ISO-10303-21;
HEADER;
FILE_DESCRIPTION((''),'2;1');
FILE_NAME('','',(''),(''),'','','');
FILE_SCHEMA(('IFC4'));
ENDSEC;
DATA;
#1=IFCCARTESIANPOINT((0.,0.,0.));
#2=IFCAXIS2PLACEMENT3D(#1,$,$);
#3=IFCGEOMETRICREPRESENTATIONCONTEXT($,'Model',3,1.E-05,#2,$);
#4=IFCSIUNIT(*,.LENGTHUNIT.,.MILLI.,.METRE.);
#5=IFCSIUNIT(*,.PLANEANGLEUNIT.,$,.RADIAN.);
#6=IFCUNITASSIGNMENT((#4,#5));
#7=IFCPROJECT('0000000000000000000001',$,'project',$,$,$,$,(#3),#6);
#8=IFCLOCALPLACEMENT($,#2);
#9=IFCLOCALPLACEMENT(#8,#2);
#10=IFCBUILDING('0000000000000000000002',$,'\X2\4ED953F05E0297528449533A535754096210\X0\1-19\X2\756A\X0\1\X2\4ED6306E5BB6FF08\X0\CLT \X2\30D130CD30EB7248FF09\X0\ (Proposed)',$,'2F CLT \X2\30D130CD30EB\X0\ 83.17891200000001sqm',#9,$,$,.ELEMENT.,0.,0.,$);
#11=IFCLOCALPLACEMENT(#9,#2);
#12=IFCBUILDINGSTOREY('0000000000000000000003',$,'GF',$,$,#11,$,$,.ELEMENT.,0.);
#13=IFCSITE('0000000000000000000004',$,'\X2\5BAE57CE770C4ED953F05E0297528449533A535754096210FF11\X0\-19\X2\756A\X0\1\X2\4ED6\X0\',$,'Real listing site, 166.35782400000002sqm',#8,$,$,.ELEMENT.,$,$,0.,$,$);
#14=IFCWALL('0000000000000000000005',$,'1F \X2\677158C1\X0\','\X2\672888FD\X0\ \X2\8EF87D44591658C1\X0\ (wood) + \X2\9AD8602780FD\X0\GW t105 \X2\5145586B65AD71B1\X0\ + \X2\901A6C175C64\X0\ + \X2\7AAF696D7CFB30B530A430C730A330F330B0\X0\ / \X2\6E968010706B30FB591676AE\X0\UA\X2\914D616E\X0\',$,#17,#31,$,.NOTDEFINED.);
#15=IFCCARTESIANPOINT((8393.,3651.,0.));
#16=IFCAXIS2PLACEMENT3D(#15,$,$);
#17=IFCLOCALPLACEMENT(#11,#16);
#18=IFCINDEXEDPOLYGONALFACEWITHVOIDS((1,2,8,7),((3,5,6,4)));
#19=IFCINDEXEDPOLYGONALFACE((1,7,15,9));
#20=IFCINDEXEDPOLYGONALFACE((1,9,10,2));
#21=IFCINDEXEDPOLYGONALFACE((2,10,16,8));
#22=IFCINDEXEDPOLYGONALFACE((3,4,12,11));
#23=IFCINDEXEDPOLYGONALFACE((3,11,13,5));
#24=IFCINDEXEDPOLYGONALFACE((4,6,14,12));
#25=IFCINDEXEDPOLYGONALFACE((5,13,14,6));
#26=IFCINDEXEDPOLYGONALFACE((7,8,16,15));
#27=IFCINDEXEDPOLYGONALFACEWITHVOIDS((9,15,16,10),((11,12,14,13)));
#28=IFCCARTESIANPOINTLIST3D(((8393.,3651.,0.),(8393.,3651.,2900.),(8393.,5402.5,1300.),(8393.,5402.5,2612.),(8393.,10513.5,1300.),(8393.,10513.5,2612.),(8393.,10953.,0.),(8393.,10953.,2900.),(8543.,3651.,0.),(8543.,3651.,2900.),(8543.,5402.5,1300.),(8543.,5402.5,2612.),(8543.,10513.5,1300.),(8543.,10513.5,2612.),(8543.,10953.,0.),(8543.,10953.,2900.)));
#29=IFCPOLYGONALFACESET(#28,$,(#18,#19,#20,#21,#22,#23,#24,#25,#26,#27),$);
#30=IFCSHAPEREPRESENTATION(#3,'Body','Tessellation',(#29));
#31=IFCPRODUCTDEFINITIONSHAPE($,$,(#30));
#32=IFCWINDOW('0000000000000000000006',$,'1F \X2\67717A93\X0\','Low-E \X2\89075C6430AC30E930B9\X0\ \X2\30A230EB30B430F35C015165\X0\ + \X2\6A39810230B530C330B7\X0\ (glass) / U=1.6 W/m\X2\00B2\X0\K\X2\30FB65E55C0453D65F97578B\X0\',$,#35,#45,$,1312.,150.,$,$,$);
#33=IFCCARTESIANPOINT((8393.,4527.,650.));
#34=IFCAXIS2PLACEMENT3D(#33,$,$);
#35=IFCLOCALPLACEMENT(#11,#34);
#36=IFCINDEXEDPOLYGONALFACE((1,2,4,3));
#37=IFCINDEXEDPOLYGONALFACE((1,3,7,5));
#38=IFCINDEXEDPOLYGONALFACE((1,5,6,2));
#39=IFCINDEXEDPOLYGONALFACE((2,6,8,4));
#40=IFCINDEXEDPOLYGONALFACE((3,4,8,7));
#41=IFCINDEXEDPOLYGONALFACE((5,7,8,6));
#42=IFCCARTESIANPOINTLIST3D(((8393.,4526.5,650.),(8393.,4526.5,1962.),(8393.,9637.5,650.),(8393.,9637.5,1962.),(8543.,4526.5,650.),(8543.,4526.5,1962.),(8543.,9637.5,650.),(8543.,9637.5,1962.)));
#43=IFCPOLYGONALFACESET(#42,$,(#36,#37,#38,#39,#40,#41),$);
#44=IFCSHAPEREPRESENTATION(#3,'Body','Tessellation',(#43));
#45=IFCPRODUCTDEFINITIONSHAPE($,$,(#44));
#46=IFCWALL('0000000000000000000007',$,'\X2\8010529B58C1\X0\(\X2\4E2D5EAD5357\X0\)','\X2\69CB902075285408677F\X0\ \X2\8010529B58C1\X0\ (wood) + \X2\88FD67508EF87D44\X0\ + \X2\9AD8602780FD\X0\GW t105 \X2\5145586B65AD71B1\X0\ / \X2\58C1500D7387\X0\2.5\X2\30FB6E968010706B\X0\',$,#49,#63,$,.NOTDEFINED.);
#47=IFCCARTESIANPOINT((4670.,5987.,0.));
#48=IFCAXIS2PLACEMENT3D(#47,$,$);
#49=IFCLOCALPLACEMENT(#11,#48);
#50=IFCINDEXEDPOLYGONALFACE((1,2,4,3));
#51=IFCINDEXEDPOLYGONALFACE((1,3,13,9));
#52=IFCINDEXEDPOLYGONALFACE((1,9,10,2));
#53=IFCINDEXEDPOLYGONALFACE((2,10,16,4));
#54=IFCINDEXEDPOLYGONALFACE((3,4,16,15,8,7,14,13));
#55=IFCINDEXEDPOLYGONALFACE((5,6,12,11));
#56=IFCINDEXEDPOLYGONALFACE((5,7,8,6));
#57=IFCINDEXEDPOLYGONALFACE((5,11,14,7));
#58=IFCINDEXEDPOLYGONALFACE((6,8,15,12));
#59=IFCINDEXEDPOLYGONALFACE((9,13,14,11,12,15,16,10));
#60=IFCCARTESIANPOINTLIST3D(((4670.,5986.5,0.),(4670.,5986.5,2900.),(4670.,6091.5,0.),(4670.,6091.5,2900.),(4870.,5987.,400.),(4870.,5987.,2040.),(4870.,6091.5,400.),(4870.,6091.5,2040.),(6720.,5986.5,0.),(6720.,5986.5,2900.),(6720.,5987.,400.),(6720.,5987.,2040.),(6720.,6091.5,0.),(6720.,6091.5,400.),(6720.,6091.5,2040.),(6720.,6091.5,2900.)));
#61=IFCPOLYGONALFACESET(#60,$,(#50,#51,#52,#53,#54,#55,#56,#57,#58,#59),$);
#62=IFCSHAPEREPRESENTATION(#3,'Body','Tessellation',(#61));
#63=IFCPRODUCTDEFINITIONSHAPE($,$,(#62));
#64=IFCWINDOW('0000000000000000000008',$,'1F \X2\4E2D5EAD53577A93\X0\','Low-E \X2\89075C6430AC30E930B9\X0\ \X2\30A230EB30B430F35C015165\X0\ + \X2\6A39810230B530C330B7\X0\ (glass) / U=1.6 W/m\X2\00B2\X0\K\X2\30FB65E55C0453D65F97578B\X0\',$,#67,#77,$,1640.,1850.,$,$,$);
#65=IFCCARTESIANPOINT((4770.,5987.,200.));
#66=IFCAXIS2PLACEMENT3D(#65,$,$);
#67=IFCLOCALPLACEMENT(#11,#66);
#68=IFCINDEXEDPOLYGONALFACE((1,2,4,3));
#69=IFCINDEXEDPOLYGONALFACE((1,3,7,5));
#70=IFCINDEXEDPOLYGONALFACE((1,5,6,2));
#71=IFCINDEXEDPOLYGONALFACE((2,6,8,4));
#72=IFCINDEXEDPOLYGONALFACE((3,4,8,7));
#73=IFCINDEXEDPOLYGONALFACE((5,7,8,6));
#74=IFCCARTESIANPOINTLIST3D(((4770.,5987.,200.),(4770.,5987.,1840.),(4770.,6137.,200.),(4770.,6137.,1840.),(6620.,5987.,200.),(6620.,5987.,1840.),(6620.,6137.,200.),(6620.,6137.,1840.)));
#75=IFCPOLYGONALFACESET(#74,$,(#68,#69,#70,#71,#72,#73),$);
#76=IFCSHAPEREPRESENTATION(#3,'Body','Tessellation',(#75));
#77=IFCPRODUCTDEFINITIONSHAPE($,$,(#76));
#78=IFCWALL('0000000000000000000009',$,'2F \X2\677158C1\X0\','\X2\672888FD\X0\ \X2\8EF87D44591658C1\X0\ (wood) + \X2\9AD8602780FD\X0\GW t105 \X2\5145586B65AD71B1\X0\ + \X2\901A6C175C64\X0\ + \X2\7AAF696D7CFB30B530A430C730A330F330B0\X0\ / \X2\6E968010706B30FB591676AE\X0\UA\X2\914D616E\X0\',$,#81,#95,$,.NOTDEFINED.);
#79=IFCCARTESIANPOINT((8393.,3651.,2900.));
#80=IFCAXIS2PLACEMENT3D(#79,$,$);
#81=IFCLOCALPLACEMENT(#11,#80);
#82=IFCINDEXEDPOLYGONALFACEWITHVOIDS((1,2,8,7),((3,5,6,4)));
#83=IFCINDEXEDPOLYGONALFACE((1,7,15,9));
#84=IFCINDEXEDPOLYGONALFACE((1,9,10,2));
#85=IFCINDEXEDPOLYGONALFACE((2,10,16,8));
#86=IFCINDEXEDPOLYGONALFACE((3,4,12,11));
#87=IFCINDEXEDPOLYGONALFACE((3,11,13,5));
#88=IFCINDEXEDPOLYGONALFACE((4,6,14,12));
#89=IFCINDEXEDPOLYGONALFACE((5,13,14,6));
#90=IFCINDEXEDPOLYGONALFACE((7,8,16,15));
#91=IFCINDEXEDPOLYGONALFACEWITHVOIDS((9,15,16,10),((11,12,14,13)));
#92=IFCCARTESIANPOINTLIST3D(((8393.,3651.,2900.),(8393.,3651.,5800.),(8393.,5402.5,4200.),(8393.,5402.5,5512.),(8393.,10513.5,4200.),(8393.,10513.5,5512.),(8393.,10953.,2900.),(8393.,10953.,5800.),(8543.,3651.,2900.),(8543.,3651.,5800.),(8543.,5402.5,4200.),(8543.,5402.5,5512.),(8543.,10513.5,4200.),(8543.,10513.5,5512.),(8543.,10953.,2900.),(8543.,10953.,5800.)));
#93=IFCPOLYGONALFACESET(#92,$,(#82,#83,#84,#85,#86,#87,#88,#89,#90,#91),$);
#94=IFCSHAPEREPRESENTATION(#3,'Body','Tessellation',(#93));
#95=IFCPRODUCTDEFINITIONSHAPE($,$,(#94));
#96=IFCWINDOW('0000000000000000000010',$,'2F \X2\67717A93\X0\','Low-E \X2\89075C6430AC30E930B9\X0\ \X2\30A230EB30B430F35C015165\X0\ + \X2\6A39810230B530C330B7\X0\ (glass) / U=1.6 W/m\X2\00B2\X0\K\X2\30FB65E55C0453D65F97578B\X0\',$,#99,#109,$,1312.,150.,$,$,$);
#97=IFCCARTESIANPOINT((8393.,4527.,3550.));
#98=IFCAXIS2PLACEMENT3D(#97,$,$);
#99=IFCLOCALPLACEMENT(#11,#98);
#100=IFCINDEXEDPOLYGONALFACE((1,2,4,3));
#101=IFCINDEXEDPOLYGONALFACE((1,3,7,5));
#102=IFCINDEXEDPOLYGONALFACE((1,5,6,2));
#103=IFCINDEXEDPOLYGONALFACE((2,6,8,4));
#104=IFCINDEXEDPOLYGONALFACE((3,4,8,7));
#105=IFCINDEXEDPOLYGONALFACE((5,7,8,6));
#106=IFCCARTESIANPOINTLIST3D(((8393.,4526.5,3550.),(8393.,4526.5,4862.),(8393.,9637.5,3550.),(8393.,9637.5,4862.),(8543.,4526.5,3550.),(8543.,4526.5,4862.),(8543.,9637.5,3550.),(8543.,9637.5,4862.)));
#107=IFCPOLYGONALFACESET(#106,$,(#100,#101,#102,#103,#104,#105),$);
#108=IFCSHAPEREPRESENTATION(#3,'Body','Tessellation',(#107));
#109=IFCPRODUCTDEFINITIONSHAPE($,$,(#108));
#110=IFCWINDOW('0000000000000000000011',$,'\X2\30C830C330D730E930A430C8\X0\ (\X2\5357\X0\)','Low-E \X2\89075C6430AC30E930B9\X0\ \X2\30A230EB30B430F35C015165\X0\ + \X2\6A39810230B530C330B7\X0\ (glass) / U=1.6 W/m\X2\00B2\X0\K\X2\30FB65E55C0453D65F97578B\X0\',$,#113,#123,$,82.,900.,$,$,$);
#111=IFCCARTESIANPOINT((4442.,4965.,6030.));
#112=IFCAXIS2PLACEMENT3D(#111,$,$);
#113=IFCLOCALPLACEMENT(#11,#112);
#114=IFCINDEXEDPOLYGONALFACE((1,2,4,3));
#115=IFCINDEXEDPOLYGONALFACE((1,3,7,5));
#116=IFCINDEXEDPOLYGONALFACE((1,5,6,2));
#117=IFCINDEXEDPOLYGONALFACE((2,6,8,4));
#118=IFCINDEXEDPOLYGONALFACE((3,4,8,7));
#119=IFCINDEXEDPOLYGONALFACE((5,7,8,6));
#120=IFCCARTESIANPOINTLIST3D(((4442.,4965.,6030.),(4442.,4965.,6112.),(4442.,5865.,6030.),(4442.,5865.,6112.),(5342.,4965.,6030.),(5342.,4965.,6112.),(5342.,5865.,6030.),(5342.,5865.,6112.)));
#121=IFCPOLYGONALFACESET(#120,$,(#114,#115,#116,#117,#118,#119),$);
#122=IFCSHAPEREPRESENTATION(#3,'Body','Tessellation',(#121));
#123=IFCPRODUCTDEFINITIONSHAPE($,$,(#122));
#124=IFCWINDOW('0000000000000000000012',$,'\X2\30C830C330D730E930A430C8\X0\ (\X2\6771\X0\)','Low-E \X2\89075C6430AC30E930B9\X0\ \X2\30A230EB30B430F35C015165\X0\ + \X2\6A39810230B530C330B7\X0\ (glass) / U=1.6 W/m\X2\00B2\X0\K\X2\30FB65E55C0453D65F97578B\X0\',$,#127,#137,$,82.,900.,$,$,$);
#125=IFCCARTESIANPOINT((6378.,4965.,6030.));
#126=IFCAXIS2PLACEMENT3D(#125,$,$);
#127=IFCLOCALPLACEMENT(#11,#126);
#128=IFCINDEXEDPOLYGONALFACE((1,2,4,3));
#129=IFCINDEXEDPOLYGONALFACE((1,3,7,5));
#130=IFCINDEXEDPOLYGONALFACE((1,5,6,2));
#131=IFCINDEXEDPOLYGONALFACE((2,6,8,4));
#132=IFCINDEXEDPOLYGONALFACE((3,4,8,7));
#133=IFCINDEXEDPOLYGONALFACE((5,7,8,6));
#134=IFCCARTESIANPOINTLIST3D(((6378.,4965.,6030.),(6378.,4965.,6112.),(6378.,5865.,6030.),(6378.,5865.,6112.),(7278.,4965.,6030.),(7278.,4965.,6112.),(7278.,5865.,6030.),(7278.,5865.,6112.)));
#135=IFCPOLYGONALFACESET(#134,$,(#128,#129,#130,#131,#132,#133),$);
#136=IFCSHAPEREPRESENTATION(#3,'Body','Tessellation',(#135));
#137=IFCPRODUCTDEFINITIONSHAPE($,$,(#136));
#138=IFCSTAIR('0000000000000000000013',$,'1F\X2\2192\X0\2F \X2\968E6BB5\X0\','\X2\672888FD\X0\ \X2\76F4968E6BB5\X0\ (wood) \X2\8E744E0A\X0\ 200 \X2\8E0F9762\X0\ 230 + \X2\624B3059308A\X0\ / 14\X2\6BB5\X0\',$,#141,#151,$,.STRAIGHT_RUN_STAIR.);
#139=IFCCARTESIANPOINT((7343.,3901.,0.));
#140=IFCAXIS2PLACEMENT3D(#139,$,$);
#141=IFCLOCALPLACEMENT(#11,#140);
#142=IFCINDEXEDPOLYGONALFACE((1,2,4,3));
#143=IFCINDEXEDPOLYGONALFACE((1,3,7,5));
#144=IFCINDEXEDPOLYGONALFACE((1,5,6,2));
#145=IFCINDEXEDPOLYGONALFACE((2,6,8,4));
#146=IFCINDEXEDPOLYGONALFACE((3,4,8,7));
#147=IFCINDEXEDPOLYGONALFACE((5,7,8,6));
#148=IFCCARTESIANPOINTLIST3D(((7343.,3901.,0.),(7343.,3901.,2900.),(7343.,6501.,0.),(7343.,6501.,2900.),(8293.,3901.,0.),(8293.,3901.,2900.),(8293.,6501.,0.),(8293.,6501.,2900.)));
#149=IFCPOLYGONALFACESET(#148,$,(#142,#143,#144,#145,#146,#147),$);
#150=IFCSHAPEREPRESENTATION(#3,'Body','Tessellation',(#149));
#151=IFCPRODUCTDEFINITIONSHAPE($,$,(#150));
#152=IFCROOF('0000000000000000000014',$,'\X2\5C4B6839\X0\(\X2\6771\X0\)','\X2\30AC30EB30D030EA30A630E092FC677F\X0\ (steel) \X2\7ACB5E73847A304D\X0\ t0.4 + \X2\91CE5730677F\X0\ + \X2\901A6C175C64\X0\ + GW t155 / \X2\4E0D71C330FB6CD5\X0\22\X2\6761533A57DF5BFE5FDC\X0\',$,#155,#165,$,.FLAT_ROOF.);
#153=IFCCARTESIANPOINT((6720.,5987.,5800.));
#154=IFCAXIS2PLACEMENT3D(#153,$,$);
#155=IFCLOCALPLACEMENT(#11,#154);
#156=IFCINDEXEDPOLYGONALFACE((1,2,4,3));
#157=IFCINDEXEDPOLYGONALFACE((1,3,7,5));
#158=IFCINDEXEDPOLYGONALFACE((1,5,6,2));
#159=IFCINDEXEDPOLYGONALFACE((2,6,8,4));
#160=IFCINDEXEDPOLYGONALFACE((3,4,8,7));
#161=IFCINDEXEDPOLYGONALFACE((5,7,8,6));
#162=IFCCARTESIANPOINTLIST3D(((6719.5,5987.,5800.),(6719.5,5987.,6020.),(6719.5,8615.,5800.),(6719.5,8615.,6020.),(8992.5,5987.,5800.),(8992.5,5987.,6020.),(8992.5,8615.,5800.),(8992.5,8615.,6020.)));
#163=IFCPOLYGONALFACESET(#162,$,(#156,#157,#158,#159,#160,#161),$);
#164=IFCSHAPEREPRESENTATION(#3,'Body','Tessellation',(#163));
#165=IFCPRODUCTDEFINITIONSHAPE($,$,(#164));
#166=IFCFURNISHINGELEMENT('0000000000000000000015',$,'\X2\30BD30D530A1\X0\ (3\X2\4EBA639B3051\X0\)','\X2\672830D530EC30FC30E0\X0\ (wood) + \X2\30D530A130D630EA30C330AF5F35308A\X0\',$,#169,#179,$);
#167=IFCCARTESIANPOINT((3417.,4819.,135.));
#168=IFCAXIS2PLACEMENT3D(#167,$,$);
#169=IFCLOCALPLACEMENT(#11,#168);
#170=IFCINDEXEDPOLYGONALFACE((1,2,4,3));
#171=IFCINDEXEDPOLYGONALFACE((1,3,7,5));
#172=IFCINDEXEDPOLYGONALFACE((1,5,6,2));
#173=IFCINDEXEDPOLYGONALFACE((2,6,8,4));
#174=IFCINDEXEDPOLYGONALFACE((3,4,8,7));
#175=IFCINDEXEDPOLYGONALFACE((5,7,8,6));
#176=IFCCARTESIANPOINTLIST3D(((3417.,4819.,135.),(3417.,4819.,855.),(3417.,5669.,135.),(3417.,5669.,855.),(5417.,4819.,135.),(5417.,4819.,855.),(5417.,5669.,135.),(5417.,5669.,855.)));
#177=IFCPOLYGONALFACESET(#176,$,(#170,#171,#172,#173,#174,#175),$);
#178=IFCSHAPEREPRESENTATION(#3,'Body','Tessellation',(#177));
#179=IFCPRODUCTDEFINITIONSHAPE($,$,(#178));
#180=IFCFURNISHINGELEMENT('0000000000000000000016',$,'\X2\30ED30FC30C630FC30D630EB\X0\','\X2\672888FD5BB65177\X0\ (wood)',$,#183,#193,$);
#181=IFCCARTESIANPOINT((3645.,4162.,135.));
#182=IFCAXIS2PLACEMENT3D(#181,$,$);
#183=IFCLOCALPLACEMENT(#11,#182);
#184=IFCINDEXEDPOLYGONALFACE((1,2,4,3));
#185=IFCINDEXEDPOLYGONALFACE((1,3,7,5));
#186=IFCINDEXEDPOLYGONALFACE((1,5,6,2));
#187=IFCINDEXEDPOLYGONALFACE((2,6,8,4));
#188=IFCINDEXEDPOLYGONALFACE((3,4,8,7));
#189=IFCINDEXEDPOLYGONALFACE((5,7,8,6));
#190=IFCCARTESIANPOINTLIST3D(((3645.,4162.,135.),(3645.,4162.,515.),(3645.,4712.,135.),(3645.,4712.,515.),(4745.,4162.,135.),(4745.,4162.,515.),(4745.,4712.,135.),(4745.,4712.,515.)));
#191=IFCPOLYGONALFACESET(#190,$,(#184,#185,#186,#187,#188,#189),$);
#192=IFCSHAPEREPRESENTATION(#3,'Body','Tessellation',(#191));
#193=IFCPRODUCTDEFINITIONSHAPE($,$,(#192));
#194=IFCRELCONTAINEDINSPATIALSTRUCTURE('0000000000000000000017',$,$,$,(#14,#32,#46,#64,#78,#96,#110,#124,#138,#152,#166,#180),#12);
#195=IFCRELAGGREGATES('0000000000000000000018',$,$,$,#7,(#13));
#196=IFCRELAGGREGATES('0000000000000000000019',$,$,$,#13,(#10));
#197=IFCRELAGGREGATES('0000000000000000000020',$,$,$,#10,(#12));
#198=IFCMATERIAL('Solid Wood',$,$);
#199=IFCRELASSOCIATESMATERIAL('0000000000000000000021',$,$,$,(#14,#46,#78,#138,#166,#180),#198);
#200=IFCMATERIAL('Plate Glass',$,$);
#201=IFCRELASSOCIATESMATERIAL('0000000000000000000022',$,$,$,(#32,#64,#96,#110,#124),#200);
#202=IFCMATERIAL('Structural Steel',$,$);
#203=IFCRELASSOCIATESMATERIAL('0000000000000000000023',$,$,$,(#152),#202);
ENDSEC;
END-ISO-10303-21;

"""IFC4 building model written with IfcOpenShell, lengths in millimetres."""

from ifc_helpers import new_model, si_unit, frame, frame_2d, origin, place, context, project, spatial, rectangle, extrude, material, element, fill, save


model = new_model("IFC4")

# Units and contexts
model_context = context("Model", 3, precision=1e-05, world=origin())
ifc_project = project(units=[si_unit("LENGTHUNIT", "METRE", prefix="MILLI"), si_unit("PLANEANGLEUNIT", "RADIAN")], contexts=[model_context])

# Site, building, storey
site_placement = place(None, origin())
site = spatial("IfcSite", under=ifc_project, at=site_placement, Name="宮城県仙台市青葉区南吉成１-19番1他", ObjectType="Real listing site, 166.35782400000002sqm", CompositionType="ELEMENT", RefElevation=0.0)
building_placement = place(site_placement, origin())
building = spatial("IfcBuilding", under=site, at=building_placement, Name="仙台市青葉区南吉成1-19番1他の家（CLT パネル版） (Proposed)", ObjectType="2F CLT パネル 83.17891200000001sqm", CompositionType="ELEMENT", ElevationOfRefHeight=0.0, ElevationOfTerrain=0.0)
storey_placement = place(building_placement, origin())
storey = spatial("IfcBuildingStorey", under=building, at=storey_placement, Name="GF", CompositionType="ELEMENT", Elevation=0.0)

# Shared definitions
ifc_material_1 = material(Name="Solid Wood")

# Walls, openings, windows
wall_1_placement = place(storey_placement, frame((8393.0, 3651.0, 0.0)))
wall_1 = element("IfcWall", 1, at=wall_1_placement, inside=storey, material=ifc_material_1, Name="1F 東壁", Description="木製 軸組外壁 (wood) + 高性能GW t105 充填断熱 + 通気層 + 窯業系サイディング / 準耐火・外皮UA配慮", PredefinedType="NOTDEFINED", context=model_context, shape_type="SweptSolid", body=[
    extrude(rectangle(XDim=150.0, YDim=7302.0, at=frame_2d((75.0, 3651.0))), frame((8393.0, 3651.0, 0.0)), (0.0, 0.0, 1.0), 2900.0),
])
opening_1_placement = place(storey_placement, frame((8393.0, 4527.0, 650.0)))
opening_1 = element("IfcOpeningElement", 2, at=opening_1_placement, cuts=wall_1, PredefinedType="NOTDEFINED", context=model_context, shape_type="SweptSolid", body=[
    extrude(rectangle(XDim=150.0, YDim=5111.0, at=frame_2d((75.0, 2555.0))), frame((8393.0, 4527.0, 650.0)), (0.0, 0.0, 1.0), 1312.0),
])
ifc_material_2 = material(Name="Plate Glass")
window_1_placement = place(storey_placement, frame((8393.0, 4527.0, 650.0)))
window_1 = element("IfcWindow", 3, at=window_1_placement, inside=storey, material=ifc_material_2, Name="1F 東窓", Description="Low-E 複層ガラス アルゴン封入 + 樹脂サッシ (glass) / U=1.6 W/m²K・日射取得型", OverallHeight=1312.0, OverallWidth=150.0, context=model_context, shape_type="SweptSolid", body=[
    extrude(rectangle(XDim=150.0, YDim=5111.0, at=frame_2d((75.0, 2555.0))), frame((8393.0, 4527.0, 650.0)), (0.0, 0.0, 1.0), 1312.0),
])
fill(opening_1, window_1)
wall_2_placement = place(storey_placement, frame((4670.0, 5987.0, 0.0)))
wall_2 = element("IfcWall", 4, at=wall_2_placement, inside=storey, material=ifc_material_1, Name="耐力壁(中庭南)", Description="構造用合板 耐力壁 (wood) + 製材軸組 + 高性能GW t105 充填断熱 / 壁倍率2.5・準耐火", PredefinedType="NOTDEFINED", context=model_context, shape_type="SweptSolid", body=[
    extrude(rectangle(XDim=2050.0, YDim=105.0, at=frame_2d((1025.0, 52.0))), frame((4670.0, 5987.0, 0.0)), (0.0, 0.0, 1.0), 2900.0),
])
opening_2_placement = place(storey_placement, frame((4770.0, 5987.0, 200.0)))
opening_2 = element("IfcOpeningElement", 5, at=opening_2_placement, cuts=wall_2, PredefinedType="NOTDEFINED", context=model_context, shape_type="SweptSolid", body=[
    extrude(rectangle(XDim=1850.0, YDim=150.0, at=frame_2d((925.0, 75.0))), frame((4770.0, 5987.0, 200.0)), (0.0, 0.0, 1.0), 1640.0),
])
window_2_placement = place(storey_placement, frame((4770.0, 5987.0, 200.0)))
window_2 = element("IfcWindow", 6, at=window_2_placement, inside=storey, material=ifc_material_2, Name="1F 中庭南窓", Description="Low-E 複層ガラス アルゴン封入 + 樹脂サッシ (glass) / U=1.6 W/m²K・日射取得型", OverallHeight=1640.0, OverallWidth=1850.0, context=model_context, shape_type="SweptSolid", body=[
    extrude(rectangle(XDim=1850.0, YDim=150.0, at=frame_2d((925.0, 75.0))), frame((4770.0, 5987.0, 200.0)), (0.0, 0.0, 1.0), 1640.0),
])
fill(opening_2, window_2)

# Wall, opening, window
wall_3_placement = place(storey_placement, frame((8393.0, 3651.0, 2900.0)))
wall_3 = element("IfcWall", 7, at=wall_3_placement, inside=storey, material=ifc_material_1, Name="2F 東壁", Description="木製 軸組外壁 (wood) + 高性能GW t105 充填断熱 + 通気層 + 窯業系サイディング / 準耐火・外皮UA配慮", PredefinedType="NOTDEFINED", context=model_context, shape_type="SweptSolid", body=[
    extrude(rectangle(XDim=150.0, YDim=7302.0, at=frame_2d((75.0, 3651.0))), frame((8393.0, 3651.0, 2900.0)), (0.0, 0.0, 1.0), 2900.0),
])
opening_3_placement = place(storey_placement, frame((8393.0, 4527.0, 3550.0)))
opening_3 = element("IfcOpeningElement", 8, at=opening_3_placement, cuts=wall_3, PredefinedType="NOTDEFINED", context=model_context, shape_type="SweptSolid", body=[
    extrude(rectangle(XDim=150.0, YDim=5111.0, at=frame_2d((75.0, 2555.0))), frame((8393.0, 4527.0, 3550.0)), (0.0, 0.0, 1.0), 1312.0),
])
window_3_placement = place(storey_placement, frame((8393.0, 4527.0, 3550.0)))
window_3 = element("IfcWindow", 9, at=window_3_placement, inside=storey, material=ifc_material_2, Name="2F 東窓", Description="Low-E 複層ガラス アルゴン封入 + 樹脂サッシ (glass) / U=1.6 W/m²K・日射取得型", OverallHeight=1312.0, OverallWidth=150.0, context=model_context, shape_type="SweptSolid", body=[
    extrude(rectangle(XDim=150.0, YDim=5111.0, at=frame_2d((75.0, 2555.0))), frame((8393.0, 4527.0, 3550.0)), (0.0, 0.0, 1.0), 1312.0),
])
fill(opening_3, window_3)

# Windows
window_4_placement = place(storey_placement, frame((4442.0, 4965.0, 6030.0)))
element("IfcWindow", 10, at=window_4_placement, inside=storey, material=ifc_material_2, Name="トップライト (南)", Description="Low-E 複層ガラス アルゴン封入 + 樹脂サッシ (glass) / U=1.6 W/m²K・日射取得型", OverallHeight=82.0, OverallWidth=900.0, context=model_context, shape_type="SweptSolid", body=[
    extrude(rectangle(XDim=900.0, YDim=900.0, at=frame_2d((450.0, 450.0))), frame((4442.0, 4965.0, 6030.0)), (0.0, 0.0, 1.0), 82.0),
])
window_5_placement = place(storey_placement, frame((6378.0, 4965.0, 6030.0)))
element("IfcWindow", 11, at=window_5_placement, inside=storey, material=ifc_material_2, Name="トップライト (東)", Description="Low-E 複層ガラス アルゴン封入 + 樹脂サッシ (glass) / U=1.6 W/m²K・日射取得型", OverallHeight=82.0, OverallWidth=900.0, context=model_context, shape_type="SweptSolid", body=[
    extrude(rectangle(XDim=900.0, YDim=900.0, at=frame_2d((450.0, 450.0))), frame((6378.0, 4965.0, 6030.0)), (0.0, 0.0, 1.0), 82.0),
])

# Stair
stair_placement = place(storey_placement, frame((7343.0, 3901.0, 0.0)))
element("IfcStair", 12, at=stair_placement, inside=storey, material=ifc_material_1, Name="1F→2F 階段", Description="木製 直階段 (wood) 蹴上 200 踏面 230 + 手すり / 14段", PredefinedType="STRAIGHT_RUN_STAIR", context=model_context, shape_type="SweptSolid", body=[
    extrude(rectangle(XDim=950.0, YDim=2600.0, at=frame_2d((475.0, 1300.0))), frame((7343.0, 3901.0, 0.0)), (0.0, 0.0, 1.0), 2900.0),
])

# Roof
ifc_material_3 = material(Name="Structural Steel")
roof_placement = place(storey_placement, frame((6720.0, 5987.0, 5800.0)))
element("IfcRoof", 13, at=roof_placement, inside=storey, material=ifc_material_3, Name="屋根(東)", Description="ガルバリウム鋼板 (steel) 立平葺き t0.4 + 野地板 + 通気層 + GW t155 / 不燃・法22条区域対応", PredefinedType="FLAT_ROOF", context=model_context, shape_type="SweptSolid", body=[
    extrude(rectangle(XDim=2273.0, YDim=2628.0, at=frame_2d((1136.0, 1314.0))), frame((6720.0, 5987.0, 5800.0)), (0.0, 0.0, 1.0), 220.0),
])

# Furnishing elements
furnishing_1_placement = place(storey_placement, frame((3417.0, 4819.0, 135.0)))
element("IfcFurnishingElement", 14, at=furnishing_1_placement, inside=storey, material=ifc_material_1, Name="ソファ (3人掛け)", Description="木フレーム (wood) + ファブリック張り", context=model_context, shape_type="SweptSolid", body=[
    extrude(rectangle(XDim=2000.0, YDim=850.0, at=frame_2d((1000.0, 425.0))), frame((3417.0, 4819.0, 135.0)), (0.0, 0.0, 1.0), 720.0),
])
furnishing_2_placement = place(storey_placement, frame((3645.0, 4162.0, 135.0)))
element("IfcFurnishingElement", 15, at=furnishing_2_placement, inside=storey, material=ifc_material_1, Name="ローテーブル", Description="木製家具 (wood)", context=model_context, shape_type="SweptSolid", body=[
    extrude(rectangle(XDim=1100.0, YDim=550.0, at=frame_2d((550.0, 275.0))), frame((3645.0, 4162.0, 135.0)), (0.0, 0.0, 1.0), 380.0),
])

save(model, "model.ifc")
